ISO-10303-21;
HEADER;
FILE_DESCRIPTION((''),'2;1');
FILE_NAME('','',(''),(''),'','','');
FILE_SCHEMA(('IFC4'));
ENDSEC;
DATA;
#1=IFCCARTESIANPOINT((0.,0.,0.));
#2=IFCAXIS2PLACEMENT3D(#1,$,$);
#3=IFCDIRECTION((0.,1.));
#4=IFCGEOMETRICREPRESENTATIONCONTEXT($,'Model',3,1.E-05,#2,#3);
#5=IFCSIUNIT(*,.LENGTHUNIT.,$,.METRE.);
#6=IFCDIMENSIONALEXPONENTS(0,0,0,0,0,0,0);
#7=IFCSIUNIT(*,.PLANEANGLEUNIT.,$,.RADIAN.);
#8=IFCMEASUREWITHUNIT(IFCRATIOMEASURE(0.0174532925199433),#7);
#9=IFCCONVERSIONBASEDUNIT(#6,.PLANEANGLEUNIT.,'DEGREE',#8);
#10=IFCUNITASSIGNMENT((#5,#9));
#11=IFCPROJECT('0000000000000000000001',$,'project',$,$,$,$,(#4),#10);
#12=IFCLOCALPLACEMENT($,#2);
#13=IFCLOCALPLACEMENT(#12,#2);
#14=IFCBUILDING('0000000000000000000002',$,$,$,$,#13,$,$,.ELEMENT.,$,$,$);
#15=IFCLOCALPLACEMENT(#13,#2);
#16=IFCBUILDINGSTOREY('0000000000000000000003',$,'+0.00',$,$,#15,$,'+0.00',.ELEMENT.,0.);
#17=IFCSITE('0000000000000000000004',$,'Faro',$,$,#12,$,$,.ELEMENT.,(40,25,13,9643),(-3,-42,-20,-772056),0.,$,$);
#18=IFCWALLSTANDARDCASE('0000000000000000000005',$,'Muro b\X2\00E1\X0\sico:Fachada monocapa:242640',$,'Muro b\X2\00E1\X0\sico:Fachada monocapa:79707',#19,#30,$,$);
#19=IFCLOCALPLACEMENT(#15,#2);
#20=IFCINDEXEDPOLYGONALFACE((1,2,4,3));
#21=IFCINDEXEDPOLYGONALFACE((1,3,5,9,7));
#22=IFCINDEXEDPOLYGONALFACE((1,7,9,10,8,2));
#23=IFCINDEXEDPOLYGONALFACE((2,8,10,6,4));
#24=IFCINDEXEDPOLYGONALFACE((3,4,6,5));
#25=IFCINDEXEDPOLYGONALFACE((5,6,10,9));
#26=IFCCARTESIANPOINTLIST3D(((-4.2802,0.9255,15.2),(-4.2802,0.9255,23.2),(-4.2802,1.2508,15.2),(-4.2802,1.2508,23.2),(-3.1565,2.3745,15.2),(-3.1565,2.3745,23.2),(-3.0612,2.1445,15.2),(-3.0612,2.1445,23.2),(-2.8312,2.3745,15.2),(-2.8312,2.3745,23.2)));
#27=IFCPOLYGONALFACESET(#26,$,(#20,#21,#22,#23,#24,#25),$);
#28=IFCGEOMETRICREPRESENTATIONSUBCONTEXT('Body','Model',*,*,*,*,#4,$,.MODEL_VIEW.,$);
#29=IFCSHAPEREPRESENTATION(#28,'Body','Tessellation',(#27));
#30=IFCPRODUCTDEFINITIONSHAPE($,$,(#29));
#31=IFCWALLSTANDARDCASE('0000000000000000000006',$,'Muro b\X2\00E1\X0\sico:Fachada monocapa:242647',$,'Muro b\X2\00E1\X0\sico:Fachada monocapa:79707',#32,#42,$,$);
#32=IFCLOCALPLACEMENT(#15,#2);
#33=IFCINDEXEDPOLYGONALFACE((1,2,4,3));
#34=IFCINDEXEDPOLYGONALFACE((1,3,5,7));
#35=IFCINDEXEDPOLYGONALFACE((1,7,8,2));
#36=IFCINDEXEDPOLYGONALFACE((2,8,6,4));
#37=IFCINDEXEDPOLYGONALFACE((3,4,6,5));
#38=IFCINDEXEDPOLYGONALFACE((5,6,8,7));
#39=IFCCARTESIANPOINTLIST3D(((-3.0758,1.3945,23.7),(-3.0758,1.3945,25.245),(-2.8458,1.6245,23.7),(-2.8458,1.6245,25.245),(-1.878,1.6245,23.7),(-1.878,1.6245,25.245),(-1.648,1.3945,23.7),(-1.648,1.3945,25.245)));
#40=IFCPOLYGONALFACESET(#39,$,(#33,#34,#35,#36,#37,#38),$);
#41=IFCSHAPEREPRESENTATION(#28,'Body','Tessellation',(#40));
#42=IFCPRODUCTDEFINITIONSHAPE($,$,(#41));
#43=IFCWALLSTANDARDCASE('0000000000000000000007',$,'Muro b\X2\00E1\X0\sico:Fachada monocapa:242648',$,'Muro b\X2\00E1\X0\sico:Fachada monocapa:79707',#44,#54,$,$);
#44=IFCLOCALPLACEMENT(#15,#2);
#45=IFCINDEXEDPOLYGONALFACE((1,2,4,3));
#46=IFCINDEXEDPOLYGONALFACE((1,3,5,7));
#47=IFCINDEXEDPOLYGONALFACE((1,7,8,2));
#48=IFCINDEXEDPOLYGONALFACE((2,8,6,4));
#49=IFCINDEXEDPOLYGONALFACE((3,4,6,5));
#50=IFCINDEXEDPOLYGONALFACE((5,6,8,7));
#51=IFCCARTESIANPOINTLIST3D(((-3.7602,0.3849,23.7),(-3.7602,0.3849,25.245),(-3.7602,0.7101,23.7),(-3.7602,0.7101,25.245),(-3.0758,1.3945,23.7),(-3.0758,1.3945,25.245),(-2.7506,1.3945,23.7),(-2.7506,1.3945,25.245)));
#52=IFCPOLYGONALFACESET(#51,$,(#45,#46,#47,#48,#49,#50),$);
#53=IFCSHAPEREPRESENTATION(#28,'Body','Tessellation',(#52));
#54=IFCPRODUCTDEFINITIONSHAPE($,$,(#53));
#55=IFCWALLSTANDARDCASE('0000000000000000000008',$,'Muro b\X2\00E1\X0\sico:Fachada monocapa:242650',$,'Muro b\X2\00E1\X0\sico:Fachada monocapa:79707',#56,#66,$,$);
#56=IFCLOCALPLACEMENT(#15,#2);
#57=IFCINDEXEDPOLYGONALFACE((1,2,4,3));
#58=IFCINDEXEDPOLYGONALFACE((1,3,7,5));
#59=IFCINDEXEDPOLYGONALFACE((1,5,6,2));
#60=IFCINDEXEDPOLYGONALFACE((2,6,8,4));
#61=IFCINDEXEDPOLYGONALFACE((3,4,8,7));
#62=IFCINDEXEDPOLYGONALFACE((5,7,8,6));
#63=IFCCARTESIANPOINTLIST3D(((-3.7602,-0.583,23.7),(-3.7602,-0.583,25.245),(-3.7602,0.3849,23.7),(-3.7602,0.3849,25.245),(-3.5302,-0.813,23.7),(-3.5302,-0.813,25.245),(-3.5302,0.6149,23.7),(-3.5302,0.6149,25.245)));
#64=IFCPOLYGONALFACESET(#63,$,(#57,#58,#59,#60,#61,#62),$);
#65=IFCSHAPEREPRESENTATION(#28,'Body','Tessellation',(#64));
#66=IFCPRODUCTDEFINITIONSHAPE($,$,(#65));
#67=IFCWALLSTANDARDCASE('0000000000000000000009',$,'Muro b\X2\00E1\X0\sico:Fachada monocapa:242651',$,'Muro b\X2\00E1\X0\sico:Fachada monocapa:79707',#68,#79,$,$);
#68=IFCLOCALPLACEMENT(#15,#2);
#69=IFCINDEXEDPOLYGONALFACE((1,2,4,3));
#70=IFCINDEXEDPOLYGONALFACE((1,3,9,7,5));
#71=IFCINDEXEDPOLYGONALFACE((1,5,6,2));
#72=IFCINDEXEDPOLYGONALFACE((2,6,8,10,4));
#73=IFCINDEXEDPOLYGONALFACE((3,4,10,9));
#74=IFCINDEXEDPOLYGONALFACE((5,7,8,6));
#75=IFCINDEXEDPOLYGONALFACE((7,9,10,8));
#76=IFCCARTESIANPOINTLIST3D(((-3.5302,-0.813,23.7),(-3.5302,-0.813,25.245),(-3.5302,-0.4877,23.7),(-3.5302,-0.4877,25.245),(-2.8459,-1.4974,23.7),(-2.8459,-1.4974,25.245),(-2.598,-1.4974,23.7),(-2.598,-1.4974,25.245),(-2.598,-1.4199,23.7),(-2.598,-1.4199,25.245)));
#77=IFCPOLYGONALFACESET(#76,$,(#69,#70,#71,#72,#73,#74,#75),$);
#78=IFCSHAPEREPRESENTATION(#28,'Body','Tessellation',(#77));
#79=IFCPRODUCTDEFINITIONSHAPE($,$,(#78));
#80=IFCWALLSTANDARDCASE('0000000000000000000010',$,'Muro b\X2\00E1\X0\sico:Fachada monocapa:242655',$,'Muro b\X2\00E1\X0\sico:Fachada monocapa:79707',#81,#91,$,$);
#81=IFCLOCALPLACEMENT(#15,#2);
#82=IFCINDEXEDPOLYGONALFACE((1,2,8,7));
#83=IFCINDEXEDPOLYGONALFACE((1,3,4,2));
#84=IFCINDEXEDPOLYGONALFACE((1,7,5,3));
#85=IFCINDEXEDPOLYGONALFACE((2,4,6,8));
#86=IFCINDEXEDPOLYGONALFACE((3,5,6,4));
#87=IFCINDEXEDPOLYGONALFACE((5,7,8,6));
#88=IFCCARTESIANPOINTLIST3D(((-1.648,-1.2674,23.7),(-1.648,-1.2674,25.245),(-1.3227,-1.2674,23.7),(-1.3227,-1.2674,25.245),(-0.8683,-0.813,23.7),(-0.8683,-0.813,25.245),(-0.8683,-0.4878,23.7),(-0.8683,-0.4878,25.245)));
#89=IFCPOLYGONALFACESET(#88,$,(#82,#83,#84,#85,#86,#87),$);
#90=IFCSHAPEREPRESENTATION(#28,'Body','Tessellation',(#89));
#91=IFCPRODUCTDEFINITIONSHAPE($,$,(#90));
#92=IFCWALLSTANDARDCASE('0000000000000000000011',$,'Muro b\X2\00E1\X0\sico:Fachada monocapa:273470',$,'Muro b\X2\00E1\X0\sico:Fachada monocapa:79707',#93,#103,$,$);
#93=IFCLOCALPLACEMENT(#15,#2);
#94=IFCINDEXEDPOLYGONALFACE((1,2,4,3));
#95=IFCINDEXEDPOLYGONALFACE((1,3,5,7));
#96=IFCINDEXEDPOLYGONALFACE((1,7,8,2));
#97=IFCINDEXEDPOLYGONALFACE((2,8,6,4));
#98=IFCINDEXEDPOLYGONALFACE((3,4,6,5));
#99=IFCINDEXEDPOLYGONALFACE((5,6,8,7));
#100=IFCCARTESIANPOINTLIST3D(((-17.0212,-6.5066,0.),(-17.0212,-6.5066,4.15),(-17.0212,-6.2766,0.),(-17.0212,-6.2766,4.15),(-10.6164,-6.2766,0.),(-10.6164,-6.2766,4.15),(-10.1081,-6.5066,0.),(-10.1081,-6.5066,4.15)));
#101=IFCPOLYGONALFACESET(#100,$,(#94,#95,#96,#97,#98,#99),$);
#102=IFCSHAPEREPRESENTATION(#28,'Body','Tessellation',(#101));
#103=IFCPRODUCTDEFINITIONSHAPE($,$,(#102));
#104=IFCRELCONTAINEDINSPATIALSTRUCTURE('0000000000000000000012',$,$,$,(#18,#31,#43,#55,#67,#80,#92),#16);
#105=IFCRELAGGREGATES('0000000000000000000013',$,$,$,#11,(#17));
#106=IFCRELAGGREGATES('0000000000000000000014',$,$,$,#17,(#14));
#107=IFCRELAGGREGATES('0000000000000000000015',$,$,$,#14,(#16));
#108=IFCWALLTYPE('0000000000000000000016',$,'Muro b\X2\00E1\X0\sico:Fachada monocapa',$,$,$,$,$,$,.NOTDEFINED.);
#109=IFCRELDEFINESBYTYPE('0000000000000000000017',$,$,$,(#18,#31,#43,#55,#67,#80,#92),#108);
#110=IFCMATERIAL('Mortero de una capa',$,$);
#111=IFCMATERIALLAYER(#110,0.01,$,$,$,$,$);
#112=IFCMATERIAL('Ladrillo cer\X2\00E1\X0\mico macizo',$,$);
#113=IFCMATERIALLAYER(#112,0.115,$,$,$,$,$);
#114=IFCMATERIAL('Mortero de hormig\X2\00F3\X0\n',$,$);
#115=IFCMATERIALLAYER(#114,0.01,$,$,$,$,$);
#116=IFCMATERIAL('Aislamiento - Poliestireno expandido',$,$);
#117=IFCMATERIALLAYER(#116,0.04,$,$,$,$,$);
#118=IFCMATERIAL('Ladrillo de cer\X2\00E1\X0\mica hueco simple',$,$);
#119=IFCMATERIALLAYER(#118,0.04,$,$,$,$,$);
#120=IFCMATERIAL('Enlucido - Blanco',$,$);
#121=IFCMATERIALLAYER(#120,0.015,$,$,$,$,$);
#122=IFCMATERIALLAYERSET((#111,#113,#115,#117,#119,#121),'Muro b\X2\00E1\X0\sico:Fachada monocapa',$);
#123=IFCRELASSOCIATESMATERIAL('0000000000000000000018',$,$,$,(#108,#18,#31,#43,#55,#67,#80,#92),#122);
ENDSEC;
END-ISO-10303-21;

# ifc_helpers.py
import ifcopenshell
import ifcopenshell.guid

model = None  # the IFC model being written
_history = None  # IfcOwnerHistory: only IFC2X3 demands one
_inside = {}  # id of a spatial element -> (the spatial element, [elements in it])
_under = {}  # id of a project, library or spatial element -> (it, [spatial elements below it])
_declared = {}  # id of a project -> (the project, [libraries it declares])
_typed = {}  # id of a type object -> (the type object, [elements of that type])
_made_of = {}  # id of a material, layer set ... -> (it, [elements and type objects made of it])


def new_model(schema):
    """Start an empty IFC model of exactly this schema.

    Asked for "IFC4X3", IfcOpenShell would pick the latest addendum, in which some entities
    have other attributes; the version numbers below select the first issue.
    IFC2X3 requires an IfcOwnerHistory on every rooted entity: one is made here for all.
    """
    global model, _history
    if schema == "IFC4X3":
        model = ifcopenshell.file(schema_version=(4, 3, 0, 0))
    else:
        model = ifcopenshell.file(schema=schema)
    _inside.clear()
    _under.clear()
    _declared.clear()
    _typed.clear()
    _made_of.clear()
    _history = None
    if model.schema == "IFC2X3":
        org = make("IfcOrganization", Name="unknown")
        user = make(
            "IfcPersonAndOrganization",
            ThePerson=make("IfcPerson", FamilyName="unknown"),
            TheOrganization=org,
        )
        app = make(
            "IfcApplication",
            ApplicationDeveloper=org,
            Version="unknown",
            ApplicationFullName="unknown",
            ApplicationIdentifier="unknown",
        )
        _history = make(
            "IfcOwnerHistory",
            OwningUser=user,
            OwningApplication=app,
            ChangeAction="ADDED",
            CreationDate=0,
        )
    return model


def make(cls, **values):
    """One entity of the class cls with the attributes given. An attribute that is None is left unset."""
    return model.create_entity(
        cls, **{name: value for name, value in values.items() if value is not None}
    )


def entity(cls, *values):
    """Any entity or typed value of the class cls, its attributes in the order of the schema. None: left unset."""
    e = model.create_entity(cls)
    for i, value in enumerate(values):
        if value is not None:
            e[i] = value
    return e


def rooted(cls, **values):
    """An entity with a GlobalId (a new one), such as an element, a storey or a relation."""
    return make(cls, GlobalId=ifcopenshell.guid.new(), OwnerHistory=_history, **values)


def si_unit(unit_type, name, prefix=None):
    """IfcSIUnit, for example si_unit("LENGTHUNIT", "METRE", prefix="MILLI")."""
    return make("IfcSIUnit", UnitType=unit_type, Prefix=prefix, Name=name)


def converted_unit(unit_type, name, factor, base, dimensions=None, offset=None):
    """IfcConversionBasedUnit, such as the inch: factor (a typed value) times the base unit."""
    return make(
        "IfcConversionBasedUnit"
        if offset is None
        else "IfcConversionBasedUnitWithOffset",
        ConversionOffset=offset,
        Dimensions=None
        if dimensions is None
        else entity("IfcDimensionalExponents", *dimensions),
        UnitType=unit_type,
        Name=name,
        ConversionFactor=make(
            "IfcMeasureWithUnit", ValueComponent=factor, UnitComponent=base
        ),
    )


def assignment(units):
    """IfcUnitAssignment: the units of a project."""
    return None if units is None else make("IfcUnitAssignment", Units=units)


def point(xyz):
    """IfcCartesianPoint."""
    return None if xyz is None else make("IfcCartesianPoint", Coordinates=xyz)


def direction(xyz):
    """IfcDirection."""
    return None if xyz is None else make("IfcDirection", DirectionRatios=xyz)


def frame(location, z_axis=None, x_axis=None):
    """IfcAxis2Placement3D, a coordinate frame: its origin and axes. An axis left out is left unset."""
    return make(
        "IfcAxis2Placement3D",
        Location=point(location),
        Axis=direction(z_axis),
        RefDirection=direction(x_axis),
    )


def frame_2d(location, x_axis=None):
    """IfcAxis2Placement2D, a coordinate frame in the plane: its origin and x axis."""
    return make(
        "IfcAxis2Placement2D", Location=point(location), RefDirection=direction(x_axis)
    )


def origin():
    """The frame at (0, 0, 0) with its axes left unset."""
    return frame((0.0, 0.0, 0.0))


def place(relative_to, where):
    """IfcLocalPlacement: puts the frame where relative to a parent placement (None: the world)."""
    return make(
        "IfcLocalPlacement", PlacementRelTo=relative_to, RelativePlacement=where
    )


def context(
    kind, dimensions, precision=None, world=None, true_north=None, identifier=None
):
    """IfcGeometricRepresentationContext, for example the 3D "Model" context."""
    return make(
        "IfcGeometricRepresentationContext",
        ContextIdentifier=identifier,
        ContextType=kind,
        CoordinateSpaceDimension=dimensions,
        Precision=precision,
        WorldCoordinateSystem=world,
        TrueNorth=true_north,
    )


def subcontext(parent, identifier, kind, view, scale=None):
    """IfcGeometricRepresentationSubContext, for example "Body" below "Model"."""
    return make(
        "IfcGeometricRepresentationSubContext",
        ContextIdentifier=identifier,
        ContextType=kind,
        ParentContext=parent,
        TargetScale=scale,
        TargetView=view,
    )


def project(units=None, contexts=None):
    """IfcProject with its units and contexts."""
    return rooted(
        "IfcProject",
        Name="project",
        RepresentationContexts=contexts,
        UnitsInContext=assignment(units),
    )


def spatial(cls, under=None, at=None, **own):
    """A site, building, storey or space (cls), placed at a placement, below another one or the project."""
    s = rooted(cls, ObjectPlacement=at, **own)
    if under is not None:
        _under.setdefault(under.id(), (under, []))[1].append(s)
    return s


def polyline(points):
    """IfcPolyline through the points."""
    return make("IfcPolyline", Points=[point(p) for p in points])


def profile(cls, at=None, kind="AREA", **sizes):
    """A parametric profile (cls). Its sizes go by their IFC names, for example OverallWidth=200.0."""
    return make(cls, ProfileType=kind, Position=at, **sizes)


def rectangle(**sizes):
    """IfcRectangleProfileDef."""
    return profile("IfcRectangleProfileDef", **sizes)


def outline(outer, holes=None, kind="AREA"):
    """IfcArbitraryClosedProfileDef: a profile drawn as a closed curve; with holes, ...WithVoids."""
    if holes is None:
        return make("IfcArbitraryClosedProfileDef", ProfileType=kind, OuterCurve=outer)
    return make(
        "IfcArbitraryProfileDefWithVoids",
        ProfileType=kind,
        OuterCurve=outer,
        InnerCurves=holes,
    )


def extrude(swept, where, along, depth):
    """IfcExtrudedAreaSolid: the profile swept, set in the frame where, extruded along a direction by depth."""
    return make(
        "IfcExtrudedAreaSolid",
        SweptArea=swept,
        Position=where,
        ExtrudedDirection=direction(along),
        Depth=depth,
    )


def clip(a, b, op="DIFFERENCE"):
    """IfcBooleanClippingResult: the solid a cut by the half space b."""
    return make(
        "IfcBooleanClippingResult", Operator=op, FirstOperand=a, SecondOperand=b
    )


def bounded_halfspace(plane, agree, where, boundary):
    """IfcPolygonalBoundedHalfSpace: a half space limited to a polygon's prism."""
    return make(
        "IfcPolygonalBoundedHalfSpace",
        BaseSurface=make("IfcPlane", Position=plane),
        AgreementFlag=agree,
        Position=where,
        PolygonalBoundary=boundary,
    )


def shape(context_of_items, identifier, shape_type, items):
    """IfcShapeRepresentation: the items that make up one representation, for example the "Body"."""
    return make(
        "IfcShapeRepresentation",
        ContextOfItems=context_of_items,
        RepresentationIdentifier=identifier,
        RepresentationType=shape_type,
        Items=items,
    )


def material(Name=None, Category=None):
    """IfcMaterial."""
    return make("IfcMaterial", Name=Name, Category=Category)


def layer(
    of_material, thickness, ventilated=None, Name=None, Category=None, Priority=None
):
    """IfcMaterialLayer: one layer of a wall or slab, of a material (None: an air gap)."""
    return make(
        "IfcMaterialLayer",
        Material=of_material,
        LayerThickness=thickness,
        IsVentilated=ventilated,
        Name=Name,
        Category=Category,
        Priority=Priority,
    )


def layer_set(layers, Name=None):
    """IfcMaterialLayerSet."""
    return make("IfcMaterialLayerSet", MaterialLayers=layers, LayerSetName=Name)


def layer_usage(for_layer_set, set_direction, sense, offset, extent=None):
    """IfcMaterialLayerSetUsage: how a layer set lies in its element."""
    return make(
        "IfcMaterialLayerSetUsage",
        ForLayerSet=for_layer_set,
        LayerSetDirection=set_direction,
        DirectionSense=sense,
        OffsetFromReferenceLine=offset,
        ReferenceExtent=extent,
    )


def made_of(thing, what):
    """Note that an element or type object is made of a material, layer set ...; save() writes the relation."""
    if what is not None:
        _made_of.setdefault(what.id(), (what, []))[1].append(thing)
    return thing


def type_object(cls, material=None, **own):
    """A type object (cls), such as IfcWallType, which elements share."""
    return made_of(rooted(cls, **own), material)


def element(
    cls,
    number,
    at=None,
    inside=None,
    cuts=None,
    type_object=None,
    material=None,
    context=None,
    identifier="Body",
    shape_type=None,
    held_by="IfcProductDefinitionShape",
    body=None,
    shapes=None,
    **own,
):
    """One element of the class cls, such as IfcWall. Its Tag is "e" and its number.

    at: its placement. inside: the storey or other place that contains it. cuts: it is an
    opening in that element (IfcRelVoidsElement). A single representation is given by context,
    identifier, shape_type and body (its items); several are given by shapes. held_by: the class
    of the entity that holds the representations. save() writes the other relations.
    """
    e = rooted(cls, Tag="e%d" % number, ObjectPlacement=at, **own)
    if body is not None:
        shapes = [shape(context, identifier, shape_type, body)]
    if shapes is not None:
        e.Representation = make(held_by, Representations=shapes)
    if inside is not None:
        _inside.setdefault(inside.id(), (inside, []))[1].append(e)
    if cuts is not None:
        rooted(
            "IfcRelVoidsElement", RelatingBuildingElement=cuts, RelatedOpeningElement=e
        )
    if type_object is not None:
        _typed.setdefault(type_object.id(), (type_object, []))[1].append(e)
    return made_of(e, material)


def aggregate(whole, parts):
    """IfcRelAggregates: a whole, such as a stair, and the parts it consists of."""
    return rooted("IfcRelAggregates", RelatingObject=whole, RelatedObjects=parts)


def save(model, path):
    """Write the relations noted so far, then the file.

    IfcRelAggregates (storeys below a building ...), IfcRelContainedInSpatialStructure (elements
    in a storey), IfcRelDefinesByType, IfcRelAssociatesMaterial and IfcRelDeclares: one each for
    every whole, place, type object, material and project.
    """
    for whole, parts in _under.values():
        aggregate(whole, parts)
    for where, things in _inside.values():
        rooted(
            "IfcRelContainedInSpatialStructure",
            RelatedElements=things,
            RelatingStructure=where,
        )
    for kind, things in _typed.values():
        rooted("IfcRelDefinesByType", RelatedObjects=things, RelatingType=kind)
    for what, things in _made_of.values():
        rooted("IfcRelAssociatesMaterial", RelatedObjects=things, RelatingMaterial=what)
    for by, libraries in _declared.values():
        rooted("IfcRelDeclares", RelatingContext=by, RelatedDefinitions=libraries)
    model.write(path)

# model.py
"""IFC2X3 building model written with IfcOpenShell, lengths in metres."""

from ifc_helpers import new_model, entity, si_unit, converted_unit, direction, frame, frame_2d, origin, place, context, subcontext, project, spatial, polyline, rectangle, outline, extrude, clip, bounded_halfspace, material, layer, layer_set, layer_usage, type_object, element, save


model = new_model("IFC2X3")

# Units and contexts
model_context = context("Model", 3, precision=1e-05, world=origin(), true_north=direction((0.0, 1.0)))
body_context = subcontext(model_context, "Body", "Model", "MODEL_VIEW")
ifc_project = project(units=[si_unit("LENGTHUNIT", "METRE"), converted_unit("PLANEANGLEUNIT", "DEGREE", entity("IfcRatioMeasure", 0.0174532925199433), si_unit("PLANEANGLEUNIT", "RADIAN"), dimensions=[0, 0, 0, 0, 0, 0, 0])], contexts=[model_context])

# Site, building, storey
site_placement = place(None, origin())
site = spatial("IfcSite", under=ifc_project, at=site_placement, Name="Faro", CompositionType="ELEMENT", RefLatitude=(40, 25, 13, 9643), RefLongitude=(-3, -42, -20, -772056), RefElevation=0.0)
building_placement = place(site_placement, origin())
building = spatial("IfcBuilding", under=site, at=building_placement, CompositionType="ELEMENT")
storey_placement = place(building_placement, origin())
storey = spatial("IfcBuildingStorey", under=building, at=storey_placement, Name="+0.00", LongName="+0.00", CompositionType="ELEMENT", Elevation=0.0)

# Shared definitions
ifc_material_1 = material(Name="Mortero de una capa")
ifc_layer_1 = layer(ifc_material_1, 0.01)
ifc_material_2 = material(Name="Ladrillo cerámico macizo")
ifc_layer_2 = layer(ifc_material_2, 0.115)
ifc_material_3 = material(Name="Mortero de hormigón")
ifc_layer_3 = layer(ifc_material_3, 0.01)
ifc_material_4 = material(Name="Aislamiento - Poliestireno expandido")
ifc_layer_4 = layer(ifc_material_4, 0.04)
ifc_material_5 = material(Name="Ladrillo de cerámica hueco simple")
ifc_layer_5 = layer(ifc_material_5, 0.04)
ifc_material_6 = material(Name="Enlucido - Blanco")
ifc_layer_6 = layer(ifc_material_6, 0.015)
ifc_layer_set = layer_set([ifc_layer_1, ifc_layer_2, ifc_layer_3, ifc_layer_4, ifc_layer_5, ifc_layer_6], Name="Muro básico:Fachada monocapa")
wall_type = type_object("IfcWallType", Name="Muro básico:Fachada monocapa", PredefinedType="NOTDEFINED", material=ifc_layer_set)

# Walls
ifc_layer_usage_1 = layer_usage(ifc_layer_set, "AXIS2", "POSITIVE", -0.115)
wall_1_placement = place(storey_placement, frame((-2.9125, 2.4558, 15.2), z_axis=(0.0, 0.0, 1.0), x_axis=(-0.707121, -0.707093, 0.0)))
element("IfcWallStandardCase", 1, at=wall_1_placement, inside=storey, type_object=wall_type, material=ifc_layer_usage_1, Name="Muro básico:Fachada monocapa:242640", ObjectType="Muro básico:Fachada monocapa:79707", context=body_context, shape_type="SweptSolid", body=[
    extrude(outline(polyline([(1.8192, -0.115), (2.0492, 0.115), (0.3253, 0.115), (0.0, 0.115), (0.23, -0.115), (1.8192, -0.115)])), origin(), (0.0, 0.0, 1.0), 8.0),
])
ifc_layer_usage_2 = layer_usage(ifc_layer_set, "AXIS2", "POSITIVE", -0.115)
wall_2_placement = place(storey_placement, frame((-1.648, 1.5095, 23.7), z_axis=(0.0, 0.0, 1.0), x_axis=(-1.0, 0.0, 0.0)))
element("IfcWallStandardCase", 2, at=wall_2_placement, inside=storey, type_object=wall_type, material=ifc_layer_usage_2, Name="Muro básico:Fachada monocapa:242647", ObjectType="Muro básico:Fachada monocapa:79707", context=body_context, shape_type="Clipping", body=[
    clip(extrude(outline(polyline([(1.1979, -0.115), (1.4279, 0.115), (1.1026, 0.115), (0.0, 0.115), (0.23, -0.115), (1.1979, -0.115)])), origin(), (0.0, 0.0, 1.0), 1.545), bounded_halfspace(frame((0.23, -0.115, 1.545)), False, frame((0.23, -0.115, 1.545)), polyline([(0.0, 0.0), (0.9679, 0.0), (1.1979, 0.23), (-0.23, 0.23), (0.0, 0.0)]))),
])
ifc_layer_usage_3 = layer_usage(ifc_layer_set, "AXIS2", "POSITIVE", -0.115)
wall_3_placement = place(storey_placement, frame((-2.8319, 1.4758, 23.7), z_axis=(0.0, 0.0, 1.0), x_axis=(-0.707121, -0.707093, 0.0)))
element("IfcWallStandardCase", 3, at=wall_3_placement, inside=storey, type_object=wall_type, material=ifc_layer_usage_3, Name="Muro básico:Fachada monocapa:242648", ObjectType="Muro básico:Fachada monocapa:79707", context=body_context, shape_type="Clipping", body=[
    clip(extrude(outline(polyline([(1.1978, -0.115), (1.4278, 0.115), (1.1026, 0.115), (0.0, 0.115), (0.23, -0.115), (1.1978, -0.115)])), origin(), (0.0, 0.0, 1.0), 1.545), bounded_halfspace(frame((0.23, -0.115, 1.545), z_axis=(0.0, 0.0, 1.0), x_axis=(0.707121, -0.707093, 0.0)), False, frame((0.23, -0.115, 1.545), z_axis=(0.0, 0.0, 1.0), x_axis=(0.707121, -0.707093, 0.0)), polyline([(0.0, 0.0), (0.6844, 0.6844), (0.6844, 1.0096), (-0.3253, 0.0), (0.0, 0.0)]))),
])
ifc_layer_usage_4 = layer_usage(ifc_layer_set, "AXIS2", "POSITIVE", -0.115)
wall_4_placement = place(storey_placement, frame((-3.6452, 0.6149, 23.7), z_axis=(0.0, 0.0, 1.0), x_axis=(0.0, -1.0, 0.0)))
element("IfcWallStandardCase", 4, at=wall_4_placement, inside=storey, type_object=wall_type, material=ifc_layer_usage_4, Name="Muro básico:Fachada monocapa:242650", ObjectType="Muro básico:Fachada monocapa:79707", context=body_context, shape_type="Clipping", body=[
    clip(extrude(outline(polyline([(1.1979, -0.115), (1.4279, 0.115), (1.1026, 0.115), (0.0, 0.115), (0.23, -0.115), (1.1979, -0.115)])), origin(), (0.0, 0.0, 1.0), 1.545), bounded_halfspace(frame((0.23, -0.115, 1.545), z_axis=(0.0, 0.0, 1.0), x_axis=(0.0, -1.0, 0.0)), False, frame((0.23, -0.115, 1.545), z_axis=(0.0, 0.0, 1.0), x_axis=(0.0, -1.0, 0.0)), polyline([(0.0, 0.0), (0.0, 0.9679), (-0.23, 1.1979), (-0.23, -0.23), (0.0, 0.0)]))),
])

# Wall, opening
ifc_layer_usage_5 = layer_usage(ifc_layer_set, "AXIS2", "POSITIVE", -0.115)
wall_5_placement = place(storey_placement, frame((-3.6115, -0.5691, 23.7), z_axis=(0.0, 0.0, 1.0), x_axis=(0.707099, -0.707115, 0.0)))
wall_5 = element("IfcWallStandardCase", 5, at=wall_5_placement, inside=storey, type_object=wall_type, material=ifc_layer_usage_5, Name="Muro básico:Fachada monocapa:242651", ObjectType="Muro básico:Fachada monocapa:79707", context=body_context, shape_type="Clipping", body=[
    clip(extrude(outline(polyline([(1.1978, -0.115), (1.3731, 0.0602), (1.3183, 0.115), (1.1026, 0.115), (0.0, 0.115), (0.23, -0.115), (1.1978, -0.115)])), origin(), (0.0, 0.0, 1.0), 1.545), bounded_halfspace(frame((0.23, -0.115, 1.545), z_axis=(0.0, 0.0, 1.0), x_axis=(-0.707099, -0.707115, 0.0)), False, frame((0.23, -0.115, 1.545), z_axis=(0.0, 0.0, 1.0), x_axis=(-0.707099, -0.707115, 0.0)), polyline([(0.0, 0.0), (-0.6844, 0.6844), (-1.0096, 0.6844), (-0.7796, 0.4544), (0.0, -0.3253), (0.0, 0.0)]))),
])
opening_1_placement = place(wall_5_placement, frame((1.3731, 0.0602, 0.0)))
element("IfcOpeningElement", 6, at=opening_1_placement, cuts=wall_5, ObjectType="Opening", context=body_context, shape_type="SweptSolid", body=[
    extrude(rectangle(XDim=1.3, YDim=0.23, at=frame_2d((0.0, 0.0), x_axis=(0.0, 1.0))), frame((-0.0813, 0.0813, 0.65), z_axis=(0.707099, 0.707115, 0.0), x_axis=(0.707115, -0.707099, 0.0)), (0.0, 0.0, 1.0), 0.8),
])

# Walls
ifc_layer_usage_6 = layer_usage(ifc_layer_set, "AXIS2", "POSITIVE", -0.115)
wall_6_placement = place(storey_placement, frame((-1.5667, -1.3487, 23.7), z_axis=(0.0, 0.0, 1.0), x_axis=(0.707121, 0.707093, 0.0)))
element("IfcWallStandardCase", 7, at=wall_6_placement, inside=storey, type_object=wall_type, material=ifc_layer_usage_6, Name="Muro básico:Fachada monocapa:242655", ObjectType="Muro básico:Fachada monocapa:79707", context=body_context, shape_type="Clipping", body=[
    clip(extrude(outline(polyline([(0.8726, -0.115), (1.1026, 0.115), (0.0, 0.115), (0.23, -0.115), (0.8726, -0.115)])), origin(), (0.0, 0.0, 1.0), 1.545), bounded_halfspace(frame((0.23, -0.115, 1.545), z_axis=(0.0, 0.0, 1.0), x_axis=(-0.707121, 0.707093, 0.0)), False, frame((0.23, -0.115, 1.545), z_axis=(0.0, 0.0, 1.0), x_axis=(-0.707121, 0.707093, 0.0)), polyline([(0.0, 0.0), (-0.4544, -0.4544), (-0.4544, -0.7796), (0.3253, 0.0), (0.0, 0.0)]))),
])
ifc_layer_usage_7 = layer_usage(ifc_layer_set, "AXIS2", "NEGATIVE", 0.115)
wall_7_placement = place(storey_placement, frame((-10.1081, -6.3916, 0.0), z_axis=(0.0, 0.0, 1.0), x_axis=(-1.0, 0.0, 0.0)))
element("IfcWallStandardCase", 8, at=wall_7_placement, inside=storey, type_object=wall_type, material=ifc_layer_usage_7, Name="Muro básico:Fachada monocapa:273470", ObjectType="Muro básico:Fachada monocapa:79707", context=body_context, shape_type="SweptSolid", body=[
    extrude(outline(polyline([(6.9132, -0.115), (6.9132, 0.115), (0.0, 0.115), (0.5084, -0.115), (6.9132, -0.115)])), origin(), (0.0, 0.0, 1.0), 4.15),
])

save(model, "model.ifc")
